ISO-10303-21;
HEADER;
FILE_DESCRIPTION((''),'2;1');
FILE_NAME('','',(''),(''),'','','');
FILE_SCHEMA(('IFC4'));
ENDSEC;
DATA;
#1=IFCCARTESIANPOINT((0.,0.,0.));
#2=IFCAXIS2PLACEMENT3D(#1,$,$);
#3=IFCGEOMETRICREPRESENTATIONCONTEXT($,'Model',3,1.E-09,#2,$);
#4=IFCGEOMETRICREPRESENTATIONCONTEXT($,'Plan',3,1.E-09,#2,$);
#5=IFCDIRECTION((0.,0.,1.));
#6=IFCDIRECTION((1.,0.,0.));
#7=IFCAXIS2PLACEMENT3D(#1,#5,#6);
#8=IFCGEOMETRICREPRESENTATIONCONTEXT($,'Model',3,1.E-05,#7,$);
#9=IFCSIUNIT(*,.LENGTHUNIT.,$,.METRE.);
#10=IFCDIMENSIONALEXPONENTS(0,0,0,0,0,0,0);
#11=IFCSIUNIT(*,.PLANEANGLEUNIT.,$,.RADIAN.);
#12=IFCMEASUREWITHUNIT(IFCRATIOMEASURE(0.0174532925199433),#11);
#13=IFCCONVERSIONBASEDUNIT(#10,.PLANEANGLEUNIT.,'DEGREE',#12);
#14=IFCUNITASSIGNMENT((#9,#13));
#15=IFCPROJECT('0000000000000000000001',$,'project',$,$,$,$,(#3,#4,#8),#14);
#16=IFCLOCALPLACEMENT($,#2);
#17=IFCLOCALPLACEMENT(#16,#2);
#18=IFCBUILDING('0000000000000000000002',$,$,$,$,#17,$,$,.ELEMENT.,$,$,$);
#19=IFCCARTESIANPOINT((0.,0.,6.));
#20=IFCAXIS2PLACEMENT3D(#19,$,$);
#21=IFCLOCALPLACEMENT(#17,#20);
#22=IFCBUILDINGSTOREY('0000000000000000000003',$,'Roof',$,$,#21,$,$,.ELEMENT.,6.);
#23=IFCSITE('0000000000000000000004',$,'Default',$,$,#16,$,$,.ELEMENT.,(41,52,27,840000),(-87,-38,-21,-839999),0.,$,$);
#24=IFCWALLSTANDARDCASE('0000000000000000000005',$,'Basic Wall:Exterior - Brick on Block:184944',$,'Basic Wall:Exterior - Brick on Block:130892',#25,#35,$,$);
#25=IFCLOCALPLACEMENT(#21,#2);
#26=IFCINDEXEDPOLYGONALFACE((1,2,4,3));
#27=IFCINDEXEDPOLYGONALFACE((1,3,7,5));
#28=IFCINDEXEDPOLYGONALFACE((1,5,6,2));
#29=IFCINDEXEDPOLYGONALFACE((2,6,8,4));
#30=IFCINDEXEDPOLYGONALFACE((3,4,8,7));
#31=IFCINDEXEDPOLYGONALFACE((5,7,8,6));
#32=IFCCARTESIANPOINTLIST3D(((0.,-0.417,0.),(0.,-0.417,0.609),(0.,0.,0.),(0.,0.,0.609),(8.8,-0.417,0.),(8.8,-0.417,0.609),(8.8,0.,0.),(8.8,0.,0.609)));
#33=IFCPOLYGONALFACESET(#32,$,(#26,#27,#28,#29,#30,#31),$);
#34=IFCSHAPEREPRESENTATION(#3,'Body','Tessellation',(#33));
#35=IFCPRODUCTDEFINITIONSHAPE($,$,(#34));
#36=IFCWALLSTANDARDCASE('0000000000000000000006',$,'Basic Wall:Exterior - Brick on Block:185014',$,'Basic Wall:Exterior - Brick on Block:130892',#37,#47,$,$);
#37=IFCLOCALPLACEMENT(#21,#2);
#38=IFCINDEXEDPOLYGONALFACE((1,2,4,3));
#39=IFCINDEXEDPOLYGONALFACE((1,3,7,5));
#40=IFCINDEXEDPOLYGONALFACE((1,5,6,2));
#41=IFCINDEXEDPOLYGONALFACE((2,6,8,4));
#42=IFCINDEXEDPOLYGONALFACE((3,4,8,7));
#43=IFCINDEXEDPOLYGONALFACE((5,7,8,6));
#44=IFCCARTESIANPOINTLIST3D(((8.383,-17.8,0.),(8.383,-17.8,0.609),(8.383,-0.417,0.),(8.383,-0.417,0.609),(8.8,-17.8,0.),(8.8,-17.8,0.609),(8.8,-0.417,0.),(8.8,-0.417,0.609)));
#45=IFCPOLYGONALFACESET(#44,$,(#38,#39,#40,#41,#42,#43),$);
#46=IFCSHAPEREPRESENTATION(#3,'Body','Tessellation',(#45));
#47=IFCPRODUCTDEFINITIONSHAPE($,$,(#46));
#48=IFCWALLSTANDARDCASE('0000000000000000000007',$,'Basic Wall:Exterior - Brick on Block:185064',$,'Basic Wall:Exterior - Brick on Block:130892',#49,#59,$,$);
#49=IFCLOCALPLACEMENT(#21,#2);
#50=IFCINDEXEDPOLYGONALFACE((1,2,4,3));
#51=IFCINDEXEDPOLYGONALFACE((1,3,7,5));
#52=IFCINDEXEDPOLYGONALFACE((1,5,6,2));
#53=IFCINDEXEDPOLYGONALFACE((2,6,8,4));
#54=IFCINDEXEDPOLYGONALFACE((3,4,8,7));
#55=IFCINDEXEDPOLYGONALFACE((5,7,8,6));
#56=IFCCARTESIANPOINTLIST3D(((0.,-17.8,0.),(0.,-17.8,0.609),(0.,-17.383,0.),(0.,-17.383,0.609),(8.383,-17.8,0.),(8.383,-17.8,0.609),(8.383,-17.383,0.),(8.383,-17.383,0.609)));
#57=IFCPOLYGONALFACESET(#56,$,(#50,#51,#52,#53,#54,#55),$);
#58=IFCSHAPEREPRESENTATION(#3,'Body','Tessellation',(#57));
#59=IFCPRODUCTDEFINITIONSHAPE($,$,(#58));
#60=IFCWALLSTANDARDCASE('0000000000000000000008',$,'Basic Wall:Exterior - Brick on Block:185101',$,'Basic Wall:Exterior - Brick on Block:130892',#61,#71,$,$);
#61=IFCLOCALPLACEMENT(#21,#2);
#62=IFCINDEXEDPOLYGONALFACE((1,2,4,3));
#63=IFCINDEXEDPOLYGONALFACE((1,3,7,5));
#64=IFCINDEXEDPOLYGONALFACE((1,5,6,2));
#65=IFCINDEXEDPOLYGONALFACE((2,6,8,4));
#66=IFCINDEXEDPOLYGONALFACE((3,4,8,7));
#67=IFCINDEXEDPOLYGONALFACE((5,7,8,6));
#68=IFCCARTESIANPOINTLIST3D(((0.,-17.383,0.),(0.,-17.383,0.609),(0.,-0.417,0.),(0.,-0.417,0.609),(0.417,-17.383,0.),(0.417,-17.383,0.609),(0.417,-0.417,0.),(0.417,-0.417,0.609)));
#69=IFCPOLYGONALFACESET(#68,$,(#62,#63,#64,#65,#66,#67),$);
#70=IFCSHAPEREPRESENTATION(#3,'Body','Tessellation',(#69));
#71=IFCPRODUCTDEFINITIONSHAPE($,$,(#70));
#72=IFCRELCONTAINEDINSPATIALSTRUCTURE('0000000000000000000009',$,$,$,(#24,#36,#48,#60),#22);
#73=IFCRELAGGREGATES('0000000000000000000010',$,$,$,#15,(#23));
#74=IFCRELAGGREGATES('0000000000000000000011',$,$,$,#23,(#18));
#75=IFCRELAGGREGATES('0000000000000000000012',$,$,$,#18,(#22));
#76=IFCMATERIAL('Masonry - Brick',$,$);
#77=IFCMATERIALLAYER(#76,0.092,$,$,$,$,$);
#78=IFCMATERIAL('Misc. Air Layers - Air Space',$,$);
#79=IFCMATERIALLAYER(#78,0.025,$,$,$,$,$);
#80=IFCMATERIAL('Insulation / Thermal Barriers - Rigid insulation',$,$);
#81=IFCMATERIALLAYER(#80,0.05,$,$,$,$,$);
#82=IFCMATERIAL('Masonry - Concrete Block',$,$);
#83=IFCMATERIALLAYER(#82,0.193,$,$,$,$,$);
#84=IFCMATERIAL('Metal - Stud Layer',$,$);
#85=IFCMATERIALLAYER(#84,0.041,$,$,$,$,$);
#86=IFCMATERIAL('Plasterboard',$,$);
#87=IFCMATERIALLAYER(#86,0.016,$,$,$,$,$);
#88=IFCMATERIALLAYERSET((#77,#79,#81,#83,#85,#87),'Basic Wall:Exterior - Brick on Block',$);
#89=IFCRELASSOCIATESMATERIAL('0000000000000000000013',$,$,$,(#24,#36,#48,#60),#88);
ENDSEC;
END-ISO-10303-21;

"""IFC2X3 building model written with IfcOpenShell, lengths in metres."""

from ifc_helpers import new_model, entity, si_unit, converted_unit, frame, frame_2d, origin, origin_with_axes, place, context, project, spatial, rectangle, extrude, material, layer, layer_set, layer_usage, element, save


model = new_model("IFC2X3")

# Units and contexts
model_context_1 = context("Model", 3, precision=1e-09, world=origin())
plan_context = context("Plan", 3, precision=1e-09, world=origin())
model_context_2 = context("Model", 3, precision=1e-05, world=origin_with_axes())
ifc_project = project(units=[si_unit("LENGTHUNIT", "METRE"), converted_unit("PLANEANGLEUNIT", "DEGREE", entity("IfcRatioMeasure", 0.0174532925199433), si_unit("PLANEANGLEUNIT", "RADIAN"), dimensions=[0, 0, 0, 0, 0, 0, 0])], contexts=[model_context_1, plan_context, model_context_2])

# Site, building, storey
site_placement = place(None, origin())
site = spatial("IfcSite", under=ifc_project, at=site_placement, Name="Default", CompositionType="ELEMENT", RefLatitude=(41, 52, 27, 840000), RefLongitude=(-87, -38, -21, -839999), RefElevation=0.0)
building_placement = place(site_placement, origin())
building = spatial("IfcBuilding", under=site, at=building_placement, CompositionType="ELEMENT")
storey_placement = place(building_placement, frame((0.0, 0.0, 6.0)))
storey = spatial("IfcBuildingStorey", under=building, at=storey_placement, Name="Roof", CompositionType="ELEMENT", Elevation=6.0)

# Walls
ifc_material_1 = material(Name="Masonry - Brick")
ifc_layer_1 = layer(ifc_material_1, 0.092)
ifc_material_2 = material(Name="Misc. Air Layers - Air Space")
ifc_layer_2 = layer(ifc_material_2, 0.025)
ifc_material_3 = material(Name="Insulation / Thermal Barriers - Rigid insulation")
ifc_layer_3 = layer(ifc_material_3, 0.05)
ifc_material_4 = material(Name="Masonry - Concrete Block")
ifc_layer_4 = layer(ifc_material_4, 0.193)
ifc_material_5 = material(Name="Metal - Stud Layer")
ifc_layer_5 = layer(ifc_material_5, 0.041)
ifc_material_6 = material(Name="Plasterboard")
ifc_layer_6 = layer(ifc_material_6, 0.016)
ifc_layer_set = layer_set([ifc_layer_1, ifc_layer_2, ifc_layer_3, ifc_layer_4, ifc_layer_5, ifc_layer_6], Name="Basic Wall:Exterior - Brick on Block")
ifc_layer_usage_1 = layer_usage(ifc_layer_set, "AXIS2", "NEGATIVE", 0.2085)
wall_1_placement = place(storey_placement, frame((0.0, -0.2085, 0.0)))
element("IfcWallStandardCase", 1, at=wall_1_placement, inside=storey, material=ifc_layer_usage_1, Name="Basic Wall:Exterior - Brick on Block:184944", ObjectType="Basic Wall:Exterior - Brick on Block:130892", context=model_context_1, shape_type="SweptSolid", body=[
    extrude(rectangle(XDim=8.8, YDim=0.417, at=frame_2d((4.4, 0.0), x_axis=(-1.0, 0.0))), origin(), (0.0, 0.0, 1.0), 0.609),
])
ifc_layer_usage_2 = layer_usage(ifc_layer_set, "AXIS2", "NEGATIVE", 0.2085)
wall_2_placement = place(storey_placement, frame((8.5915, -0.417, 0.0), z_axis=(0.0, 0.0, 1.0), x_axis=(0.0, -1.0, 0.0)))
element("IfcWallStandardCase", 2, at=wall_2_placement, inside=storey, material=ifc_layer_usage_2, Name="Basic Wall:Exterior - Brick on Block:185014", ObjectType="Basic Wall:Exterior - Brick on Block:130892", context=model_context_1, shape_type="SweptSolid", body=[
    extrude(rectangle(XDim=17.383, YDim=0.417, at=frame_2d((8.6915, 0.0), x_axis=(-1.0, 0.0))), origin(), (0.0, 0.0, 1.0), 0.609),
])
ifc_layer_usage_3 = layer_usage(ifc_layer_set, "AXIS2", "NEGATIVE", 0.2085)
wall_3_placement = place(storey_placement, frame((8.383, -17.5915, 0.0), z_axis=(0.0, 0.0, 1.0), x_axis=(-1.0, 0.0, 0.0)))
element("IfcWallStandardCase", 3, at=wall_3_placement, inside=storey, material=ifc_layer_usage_3, Name="Basic Wall:Exterior - Brick on Block:185064", ObjectType="Basic Wall:Exterior - Brick on Block:130892", context=model_context_1, shape_type="SweptSolid", body=[
    extrude(rectangle(XDim=8.383, YDim=0.417, at=frame_2d((4.1915, 0.0), x_axis=(-1.0, 0.0))), origin(), (0.0, 0.0, 1.0), 0.609),
])
ifc_layer_usage_4 = layer_usage(ifc_layer_set, "AXIS2", "NEGATIVE", 0.2085)
wall_4_placement = place(storey_placement, frame((0.2085, -17.383, 0.0), z_axis=(0.0, 0.0, 1.0), x_axis=(0.0, 1.0, 0.0)))
element("IfcWallStandardCase", 4, at=wall_4_placement, inside=storey, material=ifc_layer_usage_4, Name="Basic Wall:Exterior - Brick on Block:185101", ObjectType="Basic Wall:Exterior - Brick on Block:130892", context=model_context_1, shape_type="SweptSolid", body=[
    extrude(rectangle(XDim=16.966, YDim=0.417, at=frame_2d((8.483, 0.0), x_axis=(-1.0, 0.0))), origin(), (0.0, 0.0, 1.0), 0.609),
])

save(model, "model.ifc")
